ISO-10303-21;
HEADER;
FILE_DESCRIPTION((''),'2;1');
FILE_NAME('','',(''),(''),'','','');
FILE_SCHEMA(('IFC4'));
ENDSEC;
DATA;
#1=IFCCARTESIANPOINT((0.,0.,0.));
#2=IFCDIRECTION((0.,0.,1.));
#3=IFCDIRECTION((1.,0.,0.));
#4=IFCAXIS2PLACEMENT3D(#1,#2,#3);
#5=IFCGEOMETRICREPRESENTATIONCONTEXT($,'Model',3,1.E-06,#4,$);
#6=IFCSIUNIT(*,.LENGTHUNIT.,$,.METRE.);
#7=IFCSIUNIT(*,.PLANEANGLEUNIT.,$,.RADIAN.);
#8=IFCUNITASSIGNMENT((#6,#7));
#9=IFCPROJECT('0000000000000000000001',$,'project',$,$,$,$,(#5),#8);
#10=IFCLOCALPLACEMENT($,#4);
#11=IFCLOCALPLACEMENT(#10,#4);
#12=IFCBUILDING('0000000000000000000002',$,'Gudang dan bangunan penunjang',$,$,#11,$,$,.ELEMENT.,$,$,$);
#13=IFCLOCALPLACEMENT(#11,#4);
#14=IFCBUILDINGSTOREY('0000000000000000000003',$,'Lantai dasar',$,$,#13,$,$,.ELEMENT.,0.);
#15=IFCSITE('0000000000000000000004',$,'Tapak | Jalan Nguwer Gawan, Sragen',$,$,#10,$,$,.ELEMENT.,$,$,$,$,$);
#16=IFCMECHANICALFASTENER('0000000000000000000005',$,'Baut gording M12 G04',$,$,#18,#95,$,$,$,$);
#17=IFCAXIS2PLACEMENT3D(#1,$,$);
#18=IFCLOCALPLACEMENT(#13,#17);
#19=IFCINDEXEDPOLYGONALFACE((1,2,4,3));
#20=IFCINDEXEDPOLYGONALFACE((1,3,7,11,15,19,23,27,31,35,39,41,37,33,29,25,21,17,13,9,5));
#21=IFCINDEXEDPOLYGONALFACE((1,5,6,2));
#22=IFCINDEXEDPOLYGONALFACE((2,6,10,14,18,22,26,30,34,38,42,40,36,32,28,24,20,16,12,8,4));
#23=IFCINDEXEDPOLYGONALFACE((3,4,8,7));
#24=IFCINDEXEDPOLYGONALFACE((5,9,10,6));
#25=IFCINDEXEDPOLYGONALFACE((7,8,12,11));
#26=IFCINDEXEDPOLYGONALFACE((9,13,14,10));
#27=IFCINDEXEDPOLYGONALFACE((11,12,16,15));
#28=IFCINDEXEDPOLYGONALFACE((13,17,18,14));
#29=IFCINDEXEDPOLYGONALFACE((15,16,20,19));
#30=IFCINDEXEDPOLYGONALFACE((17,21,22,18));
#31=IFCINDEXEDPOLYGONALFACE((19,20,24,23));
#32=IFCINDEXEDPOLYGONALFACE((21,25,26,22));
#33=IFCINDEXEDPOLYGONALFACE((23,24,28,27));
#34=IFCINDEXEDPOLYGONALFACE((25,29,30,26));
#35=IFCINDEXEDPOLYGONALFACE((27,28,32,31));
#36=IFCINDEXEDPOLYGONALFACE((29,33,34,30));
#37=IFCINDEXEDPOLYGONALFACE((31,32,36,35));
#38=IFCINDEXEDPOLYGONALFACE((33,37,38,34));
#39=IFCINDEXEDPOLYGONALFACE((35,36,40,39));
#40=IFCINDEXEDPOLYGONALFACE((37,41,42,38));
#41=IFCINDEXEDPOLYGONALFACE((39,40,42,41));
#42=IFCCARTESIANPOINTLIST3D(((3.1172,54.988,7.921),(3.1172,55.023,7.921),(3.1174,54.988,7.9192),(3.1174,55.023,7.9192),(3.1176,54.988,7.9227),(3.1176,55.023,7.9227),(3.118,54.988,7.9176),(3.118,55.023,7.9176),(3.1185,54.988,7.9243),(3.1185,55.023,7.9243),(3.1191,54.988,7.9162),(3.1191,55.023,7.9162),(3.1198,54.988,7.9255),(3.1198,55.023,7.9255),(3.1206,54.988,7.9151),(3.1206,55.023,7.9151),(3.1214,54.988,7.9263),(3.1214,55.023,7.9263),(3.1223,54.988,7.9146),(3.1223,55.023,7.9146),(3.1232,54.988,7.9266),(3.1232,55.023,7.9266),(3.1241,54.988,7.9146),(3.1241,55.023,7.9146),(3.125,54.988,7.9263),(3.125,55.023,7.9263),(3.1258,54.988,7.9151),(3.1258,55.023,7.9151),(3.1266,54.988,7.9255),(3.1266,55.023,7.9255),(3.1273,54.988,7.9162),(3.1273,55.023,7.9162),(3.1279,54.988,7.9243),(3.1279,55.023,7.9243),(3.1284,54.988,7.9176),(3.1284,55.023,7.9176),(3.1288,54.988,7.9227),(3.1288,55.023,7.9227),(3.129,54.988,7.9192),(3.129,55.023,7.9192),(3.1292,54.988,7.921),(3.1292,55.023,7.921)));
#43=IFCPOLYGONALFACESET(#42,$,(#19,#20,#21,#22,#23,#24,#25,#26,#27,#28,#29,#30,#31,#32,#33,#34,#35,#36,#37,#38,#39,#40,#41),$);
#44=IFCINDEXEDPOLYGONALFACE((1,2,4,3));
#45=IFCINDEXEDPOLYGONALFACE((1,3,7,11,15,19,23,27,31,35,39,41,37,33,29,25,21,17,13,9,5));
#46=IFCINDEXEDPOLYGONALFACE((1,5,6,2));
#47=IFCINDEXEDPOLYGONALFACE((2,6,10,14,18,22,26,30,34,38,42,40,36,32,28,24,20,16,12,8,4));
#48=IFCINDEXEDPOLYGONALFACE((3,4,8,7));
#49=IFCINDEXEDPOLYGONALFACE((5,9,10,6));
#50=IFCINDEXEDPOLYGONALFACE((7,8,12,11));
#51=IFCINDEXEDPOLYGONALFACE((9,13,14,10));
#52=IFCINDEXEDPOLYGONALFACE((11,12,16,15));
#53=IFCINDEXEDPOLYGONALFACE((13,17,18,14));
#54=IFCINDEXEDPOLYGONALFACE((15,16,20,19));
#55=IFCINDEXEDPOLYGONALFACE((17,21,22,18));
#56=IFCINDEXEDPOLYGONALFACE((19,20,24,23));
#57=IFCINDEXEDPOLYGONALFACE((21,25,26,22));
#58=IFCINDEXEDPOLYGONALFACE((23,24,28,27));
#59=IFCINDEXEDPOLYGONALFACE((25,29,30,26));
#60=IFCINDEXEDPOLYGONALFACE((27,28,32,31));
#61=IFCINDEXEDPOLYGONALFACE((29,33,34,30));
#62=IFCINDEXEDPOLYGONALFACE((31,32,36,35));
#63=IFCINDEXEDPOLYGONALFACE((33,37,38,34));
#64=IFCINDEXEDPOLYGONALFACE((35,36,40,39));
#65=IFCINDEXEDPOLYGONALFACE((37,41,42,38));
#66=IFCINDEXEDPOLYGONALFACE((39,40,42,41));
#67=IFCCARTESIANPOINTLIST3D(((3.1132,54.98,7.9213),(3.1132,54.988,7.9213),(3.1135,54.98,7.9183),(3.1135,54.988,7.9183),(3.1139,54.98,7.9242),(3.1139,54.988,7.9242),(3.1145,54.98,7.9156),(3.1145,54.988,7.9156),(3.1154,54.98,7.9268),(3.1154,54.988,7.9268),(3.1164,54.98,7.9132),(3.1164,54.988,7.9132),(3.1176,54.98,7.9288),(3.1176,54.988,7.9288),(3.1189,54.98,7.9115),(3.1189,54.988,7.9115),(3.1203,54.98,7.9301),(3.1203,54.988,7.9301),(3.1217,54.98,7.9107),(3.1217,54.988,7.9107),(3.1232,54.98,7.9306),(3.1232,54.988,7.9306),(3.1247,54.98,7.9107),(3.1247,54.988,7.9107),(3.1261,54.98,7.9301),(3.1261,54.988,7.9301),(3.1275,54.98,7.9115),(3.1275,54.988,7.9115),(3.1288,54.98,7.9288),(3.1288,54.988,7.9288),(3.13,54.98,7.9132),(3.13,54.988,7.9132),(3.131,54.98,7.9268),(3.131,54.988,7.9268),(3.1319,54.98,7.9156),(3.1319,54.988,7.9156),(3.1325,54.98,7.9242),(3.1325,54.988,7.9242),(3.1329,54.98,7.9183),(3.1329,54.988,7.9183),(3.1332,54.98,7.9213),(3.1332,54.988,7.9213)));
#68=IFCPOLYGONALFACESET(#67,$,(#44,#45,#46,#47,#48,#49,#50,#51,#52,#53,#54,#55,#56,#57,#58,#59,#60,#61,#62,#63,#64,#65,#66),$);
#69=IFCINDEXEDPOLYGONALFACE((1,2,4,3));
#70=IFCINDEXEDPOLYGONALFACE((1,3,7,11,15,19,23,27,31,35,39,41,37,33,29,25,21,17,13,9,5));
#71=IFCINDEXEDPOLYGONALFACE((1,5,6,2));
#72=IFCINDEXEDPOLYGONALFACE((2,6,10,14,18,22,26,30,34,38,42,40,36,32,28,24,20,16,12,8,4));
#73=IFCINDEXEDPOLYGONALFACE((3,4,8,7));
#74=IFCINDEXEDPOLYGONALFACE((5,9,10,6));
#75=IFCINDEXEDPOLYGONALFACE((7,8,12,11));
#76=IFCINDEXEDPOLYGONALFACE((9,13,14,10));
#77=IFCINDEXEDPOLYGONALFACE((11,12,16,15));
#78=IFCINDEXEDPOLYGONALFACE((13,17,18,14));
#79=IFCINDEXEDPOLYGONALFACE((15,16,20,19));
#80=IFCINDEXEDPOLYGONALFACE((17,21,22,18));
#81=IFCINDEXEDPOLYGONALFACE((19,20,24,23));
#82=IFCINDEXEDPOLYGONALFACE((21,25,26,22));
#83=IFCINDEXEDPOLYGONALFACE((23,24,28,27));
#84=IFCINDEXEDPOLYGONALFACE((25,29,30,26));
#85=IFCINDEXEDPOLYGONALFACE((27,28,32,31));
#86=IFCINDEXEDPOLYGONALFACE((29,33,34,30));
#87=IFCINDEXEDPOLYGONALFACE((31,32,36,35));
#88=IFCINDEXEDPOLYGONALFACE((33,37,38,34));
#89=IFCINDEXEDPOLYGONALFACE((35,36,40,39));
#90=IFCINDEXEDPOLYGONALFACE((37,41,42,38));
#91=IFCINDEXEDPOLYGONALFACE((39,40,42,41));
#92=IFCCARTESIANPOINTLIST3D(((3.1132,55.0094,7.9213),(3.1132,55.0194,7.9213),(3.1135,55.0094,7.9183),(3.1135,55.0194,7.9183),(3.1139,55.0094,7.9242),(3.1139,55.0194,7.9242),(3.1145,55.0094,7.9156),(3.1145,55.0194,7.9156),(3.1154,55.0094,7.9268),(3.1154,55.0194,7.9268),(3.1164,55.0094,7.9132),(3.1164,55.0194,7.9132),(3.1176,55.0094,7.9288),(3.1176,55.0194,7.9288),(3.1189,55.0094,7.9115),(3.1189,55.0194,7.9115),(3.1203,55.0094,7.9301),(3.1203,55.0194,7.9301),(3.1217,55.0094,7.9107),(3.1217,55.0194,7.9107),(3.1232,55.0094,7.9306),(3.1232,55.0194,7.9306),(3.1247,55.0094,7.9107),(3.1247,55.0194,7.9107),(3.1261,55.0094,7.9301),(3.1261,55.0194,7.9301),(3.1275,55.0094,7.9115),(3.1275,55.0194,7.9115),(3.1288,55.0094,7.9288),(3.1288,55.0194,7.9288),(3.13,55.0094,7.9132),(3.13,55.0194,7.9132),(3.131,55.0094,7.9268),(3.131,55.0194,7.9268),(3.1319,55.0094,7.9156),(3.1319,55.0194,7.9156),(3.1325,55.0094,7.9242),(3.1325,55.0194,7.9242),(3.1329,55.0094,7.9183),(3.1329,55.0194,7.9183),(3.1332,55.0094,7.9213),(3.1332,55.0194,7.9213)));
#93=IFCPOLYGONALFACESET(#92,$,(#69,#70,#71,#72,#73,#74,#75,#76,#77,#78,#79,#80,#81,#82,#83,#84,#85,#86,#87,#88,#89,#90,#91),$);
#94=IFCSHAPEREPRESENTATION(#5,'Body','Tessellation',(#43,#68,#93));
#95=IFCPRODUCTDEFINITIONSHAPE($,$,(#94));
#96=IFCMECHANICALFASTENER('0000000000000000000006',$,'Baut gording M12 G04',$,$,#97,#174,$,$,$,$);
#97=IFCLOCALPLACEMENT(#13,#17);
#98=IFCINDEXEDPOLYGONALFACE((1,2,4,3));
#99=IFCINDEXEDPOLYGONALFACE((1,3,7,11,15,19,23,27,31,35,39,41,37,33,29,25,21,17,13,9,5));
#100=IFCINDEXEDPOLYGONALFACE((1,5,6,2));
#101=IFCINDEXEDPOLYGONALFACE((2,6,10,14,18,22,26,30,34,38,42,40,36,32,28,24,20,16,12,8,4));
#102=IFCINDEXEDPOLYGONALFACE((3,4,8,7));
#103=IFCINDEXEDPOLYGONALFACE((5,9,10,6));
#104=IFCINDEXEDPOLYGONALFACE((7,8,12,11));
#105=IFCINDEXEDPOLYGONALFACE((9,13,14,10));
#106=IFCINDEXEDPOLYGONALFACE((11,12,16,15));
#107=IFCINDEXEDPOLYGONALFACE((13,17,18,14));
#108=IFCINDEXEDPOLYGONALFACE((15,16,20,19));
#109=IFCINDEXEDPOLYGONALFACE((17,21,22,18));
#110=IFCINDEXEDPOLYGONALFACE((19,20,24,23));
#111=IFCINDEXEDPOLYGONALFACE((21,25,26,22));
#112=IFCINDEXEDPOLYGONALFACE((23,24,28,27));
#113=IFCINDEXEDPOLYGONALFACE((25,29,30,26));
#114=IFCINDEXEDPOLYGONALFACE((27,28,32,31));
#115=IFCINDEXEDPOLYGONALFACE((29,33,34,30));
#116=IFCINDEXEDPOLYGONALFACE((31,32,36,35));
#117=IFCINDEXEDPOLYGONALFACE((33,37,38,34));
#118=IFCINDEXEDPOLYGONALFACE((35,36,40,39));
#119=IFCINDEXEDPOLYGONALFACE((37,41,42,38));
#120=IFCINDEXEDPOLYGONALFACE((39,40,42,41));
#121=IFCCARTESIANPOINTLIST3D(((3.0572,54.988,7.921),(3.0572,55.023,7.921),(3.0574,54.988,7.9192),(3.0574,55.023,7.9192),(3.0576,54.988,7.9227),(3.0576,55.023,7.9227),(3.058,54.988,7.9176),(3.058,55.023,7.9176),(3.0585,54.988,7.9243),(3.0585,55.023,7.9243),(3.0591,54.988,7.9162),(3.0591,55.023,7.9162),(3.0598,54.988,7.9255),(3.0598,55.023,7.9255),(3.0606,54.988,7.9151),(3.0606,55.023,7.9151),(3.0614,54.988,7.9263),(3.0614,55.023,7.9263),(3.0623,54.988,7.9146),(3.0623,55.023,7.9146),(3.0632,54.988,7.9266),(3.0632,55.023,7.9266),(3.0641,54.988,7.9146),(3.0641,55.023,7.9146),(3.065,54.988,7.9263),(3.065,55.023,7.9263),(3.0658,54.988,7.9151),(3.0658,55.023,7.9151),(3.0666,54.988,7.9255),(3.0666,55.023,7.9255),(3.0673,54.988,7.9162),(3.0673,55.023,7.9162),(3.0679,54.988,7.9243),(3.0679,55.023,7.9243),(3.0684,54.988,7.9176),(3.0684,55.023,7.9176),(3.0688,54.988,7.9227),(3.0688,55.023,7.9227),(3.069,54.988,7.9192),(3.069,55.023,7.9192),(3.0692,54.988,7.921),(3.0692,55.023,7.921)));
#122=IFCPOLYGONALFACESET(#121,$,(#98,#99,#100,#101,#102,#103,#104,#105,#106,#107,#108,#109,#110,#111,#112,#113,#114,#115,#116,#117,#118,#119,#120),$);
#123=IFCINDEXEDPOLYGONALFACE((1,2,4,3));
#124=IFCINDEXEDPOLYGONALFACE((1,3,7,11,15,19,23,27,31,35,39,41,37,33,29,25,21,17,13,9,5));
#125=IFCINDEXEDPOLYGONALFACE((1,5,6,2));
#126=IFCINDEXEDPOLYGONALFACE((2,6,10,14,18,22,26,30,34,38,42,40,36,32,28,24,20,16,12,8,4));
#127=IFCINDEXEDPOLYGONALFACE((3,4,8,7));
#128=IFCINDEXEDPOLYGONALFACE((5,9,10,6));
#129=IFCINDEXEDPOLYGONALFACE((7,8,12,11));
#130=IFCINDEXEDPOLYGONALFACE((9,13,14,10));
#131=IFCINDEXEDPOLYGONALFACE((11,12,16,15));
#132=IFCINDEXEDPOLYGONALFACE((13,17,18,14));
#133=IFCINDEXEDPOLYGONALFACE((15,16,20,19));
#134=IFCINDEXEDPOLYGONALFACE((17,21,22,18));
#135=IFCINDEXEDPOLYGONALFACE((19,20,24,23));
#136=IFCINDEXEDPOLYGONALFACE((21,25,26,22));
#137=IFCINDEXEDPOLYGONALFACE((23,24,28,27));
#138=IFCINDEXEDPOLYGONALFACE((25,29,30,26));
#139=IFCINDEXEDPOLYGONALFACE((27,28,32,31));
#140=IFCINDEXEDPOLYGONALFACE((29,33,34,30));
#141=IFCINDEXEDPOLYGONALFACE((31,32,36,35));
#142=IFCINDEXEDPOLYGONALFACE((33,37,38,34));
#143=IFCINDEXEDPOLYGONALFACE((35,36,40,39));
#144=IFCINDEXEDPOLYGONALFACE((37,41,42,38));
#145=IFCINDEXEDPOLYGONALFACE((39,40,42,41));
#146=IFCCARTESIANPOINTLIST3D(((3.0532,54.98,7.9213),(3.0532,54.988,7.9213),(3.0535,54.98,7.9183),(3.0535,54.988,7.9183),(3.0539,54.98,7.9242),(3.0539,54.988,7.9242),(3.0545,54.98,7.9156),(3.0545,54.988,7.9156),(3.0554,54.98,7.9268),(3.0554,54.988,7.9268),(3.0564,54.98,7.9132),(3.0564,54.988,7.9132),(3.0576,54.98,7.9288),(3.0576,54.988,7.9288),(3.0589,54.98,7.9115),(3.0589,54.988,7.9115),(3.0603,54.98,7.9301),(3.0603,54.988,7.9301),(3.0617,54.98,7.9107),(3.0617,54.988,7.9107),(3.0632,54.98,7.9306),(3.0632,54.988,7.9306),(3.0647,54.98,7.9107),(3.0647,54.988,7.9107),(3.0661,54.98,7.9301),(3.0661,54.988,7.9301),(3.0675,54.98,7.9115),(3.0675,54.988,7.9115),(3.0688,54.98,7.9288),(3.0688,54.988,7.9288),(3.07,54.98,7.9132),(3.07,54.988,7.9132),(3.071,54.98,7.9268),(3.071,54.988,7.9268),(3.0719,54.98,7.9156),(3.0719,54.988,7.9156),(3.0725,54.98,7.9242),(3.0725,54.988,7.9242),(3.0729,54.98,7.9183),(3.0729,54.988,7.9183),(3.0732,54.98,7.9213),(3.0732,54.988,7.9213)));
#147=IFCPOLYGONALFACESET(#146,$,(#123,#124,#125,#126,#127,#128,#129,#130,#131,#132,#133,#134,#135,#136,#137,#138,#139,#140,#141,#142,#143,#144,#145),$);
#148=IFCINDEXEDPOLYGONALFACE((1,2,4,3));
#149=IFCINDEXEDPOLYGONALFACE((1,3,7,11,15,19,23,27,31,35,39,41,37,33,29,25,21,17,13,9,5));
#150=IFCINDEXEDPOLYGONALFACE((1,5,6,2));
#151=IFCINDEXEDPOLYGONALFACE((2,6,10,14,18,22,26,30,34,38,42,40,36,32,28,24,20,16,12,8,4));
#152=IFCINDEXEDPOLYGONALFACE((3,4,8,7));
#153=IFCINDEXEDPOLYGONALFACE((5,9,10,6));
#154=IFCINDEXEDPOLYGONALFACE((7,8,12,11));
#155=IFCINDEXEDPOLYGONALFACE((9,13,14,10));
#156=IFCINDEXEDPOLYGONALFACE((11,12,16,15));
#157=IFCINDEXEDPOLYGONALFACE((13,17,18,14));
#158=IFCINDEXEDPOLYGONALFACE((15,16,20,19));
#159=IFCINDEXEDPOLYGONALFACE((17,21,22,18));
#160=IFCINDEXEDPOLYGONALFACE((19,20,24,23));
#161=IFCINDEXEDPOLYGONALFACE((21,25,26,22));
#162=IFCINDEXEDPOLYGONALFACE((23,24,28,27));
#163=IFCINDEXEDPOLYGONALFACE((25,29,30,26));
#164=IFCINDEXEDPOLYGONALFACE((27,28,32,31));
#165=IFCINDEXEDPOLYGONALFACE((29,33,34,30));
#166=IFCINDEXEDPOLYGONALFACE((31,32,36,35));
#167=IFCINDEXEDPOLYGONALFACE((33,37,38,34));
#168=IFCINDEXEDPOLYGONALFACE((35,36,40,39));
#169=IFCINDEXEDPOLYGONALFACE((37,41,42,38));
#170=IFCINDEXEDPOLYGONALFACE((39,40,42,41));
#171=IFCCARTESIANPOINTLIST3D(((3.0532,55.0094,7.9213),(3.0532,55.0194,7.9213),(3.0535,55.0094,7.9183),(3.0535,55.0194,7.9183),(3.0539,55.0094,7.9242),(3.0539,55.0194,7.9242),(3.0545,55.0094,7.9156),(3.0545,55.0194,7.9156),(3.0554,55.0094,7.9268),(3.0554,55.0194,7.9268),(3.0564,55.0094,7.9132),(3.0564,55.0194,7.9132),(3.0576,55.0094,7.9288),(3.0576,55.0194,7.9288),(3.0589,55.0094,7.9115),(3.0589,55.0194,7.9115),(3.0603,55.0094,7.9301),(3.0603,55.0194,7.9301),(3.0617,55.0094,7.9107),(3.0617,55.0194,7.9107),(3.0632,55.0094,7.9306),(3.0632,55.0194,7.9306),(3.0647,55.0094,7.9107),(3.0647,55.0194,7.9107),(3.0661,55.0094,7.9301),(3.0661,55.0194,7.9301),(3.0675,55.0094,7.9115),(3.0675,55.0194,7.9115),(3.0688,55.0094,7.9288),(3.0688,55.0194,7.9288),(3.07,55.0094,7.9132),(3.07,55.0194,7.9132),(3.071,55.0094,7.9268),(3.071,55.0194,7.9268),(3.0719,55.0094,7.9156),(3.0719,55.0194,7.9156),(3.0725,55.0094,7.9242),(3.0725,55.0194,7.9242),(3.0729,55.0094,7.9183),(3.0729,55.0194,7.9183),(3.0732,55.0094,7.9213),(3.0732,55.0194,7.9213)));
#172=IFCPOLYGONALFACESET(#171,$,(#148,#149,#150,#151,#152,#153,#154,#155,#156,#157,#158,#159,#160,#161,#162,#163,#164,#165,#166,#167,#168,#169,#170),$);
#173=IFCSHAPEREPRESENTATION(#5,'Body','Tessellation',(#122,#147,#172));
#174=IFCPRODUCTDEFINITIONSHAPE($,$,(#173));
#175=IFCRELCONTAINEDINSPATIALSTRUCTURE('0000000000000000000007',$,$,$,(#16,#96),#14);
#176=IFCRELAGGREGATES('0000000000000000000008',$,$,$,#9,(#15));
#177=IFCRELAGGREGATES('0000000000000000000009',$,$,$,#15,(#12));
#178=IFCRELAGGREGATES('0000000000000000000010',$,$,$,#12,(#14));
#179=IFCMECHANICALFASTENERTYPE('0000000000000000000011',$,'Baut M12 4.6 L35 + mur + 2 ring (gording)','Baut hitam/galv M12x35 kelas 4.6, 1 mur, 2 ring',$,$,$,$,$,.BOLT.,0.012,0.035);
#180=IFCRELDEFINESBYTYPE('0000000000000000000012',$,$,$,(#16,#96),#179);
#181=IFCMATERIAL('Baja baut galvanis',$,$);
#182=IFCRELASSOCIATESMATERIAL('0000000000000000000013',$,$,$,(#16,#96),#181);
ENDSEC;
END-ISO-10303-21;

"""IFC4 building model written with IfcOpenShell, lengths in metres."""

from ifc_helpers import new_model, si_unit, frame, origin_with_axes, place, context, project, spatial, circle, extrude, source, transform, mapped, material, type_object, type_shapes, element, save


model = new_model("IFC4")

# Units and contexts
model_context = context("Model", 3, precision=1e-06, world=origin_with_axes())
ifc_project = project(units=[si_unit("LENGTHUNIT", "METRE"), si_unit("PLANEANGLEUNIT", "RADIAN")], contexts=[model_context])

# Site, building, storey
site_placement = place(None, origin_with_axes())
site = spatial("IfcSite", under=ifc_project, at=site_placement, Name="Tapak | Jalan Nguwer Gawan, Sragen", CompositionType="ELEMENT")
building_placement = place(site_placement, origin_with_axes())
building = spatial("IfcBuilding", under=site, at=building_placement, Name="Gudang dan bangunan penunjang", CompositionType="ELEMENT")
storey_placement = place(building_placement, origin_with_axes())
storey = spatial("IfcBuildingStorey", under=building, at=storey_placement, Name="Lantai dasar", CompositionType="ELEMENT", Elevation=0.0)

# Shared definitions
placement = place(None, origin_with_axes())

# Mechanical fasteners
ifc_material_1 = material(Name="Baja baut galvanis")
mechanical_fastener_type = type_object("IfcMechanicalFastenerType", Name="Baut M12 4.6 L35 + mur + 2 ring (gording)", Description="Baut hitam/galv M12x35 kelas 4.6, 1 mur, 2 ring", NominalDiameter=0.012, NominalLength=0.035, PredefinedType="BOLT")
shared_shape = source(origin_with_axes(), model_context, "Body", "SweptSolid", [
    extrude(circle(Radius=0.006), origin_with_axes(), (0.0, 0.0, 1.0), 0.035),
    extrude(circle(Radius=0.01), frame((0.0, 0.0, -0.008), z_axis=(0.0, 0.0, 1.0), x_axis=(1.0, 0.0, 0.0)), (0.0, 0.0, 1.0), 0.008),
    extrude(circle(Radius=0.01), frame((0.0, 0.0, 0.0214), z_axis=(0.0, 0.0, 1.0), x_axis=(1.0, 0.0, 0.0)), (0.0, 0.0, 1.0), 0.01),
])
type_shapes(mechanical_fastener_type, [shared_shape])
element("IfcMechanicalFastener", 1, at=placement, inside=storey, type_object=mechanical_fastener_type, material=ifc_material_1, Name="Baut gording M12 G04", context=model_context, shape_type="MappedRepresentation", body=[
    mapped(shared_shape, transform((3.1232, 54.988, 7.9206), x_axis=(0.0, 0.0, 1.0), y_axis=(1.0, 0.0, 0.0), z_axis=(0.0, 1.0, 0.0), scale=1.0)),
])
element("IfcMechanicalFastener", 2, at=placement, inside=storey, type_object=mechanical_fastener_type, material=ifc_material_1, Name="Baut gording M12 G04", context=model_context, shape_type="MappedRepresentation", body=[
    mapped(shared_shape, transform((3.0632, 54.988, 7.9206), x_axis=(0.0, 0.0, 1.0), y_axis=(1.0, 0.0, 0.0), z_axis=(0.0, 1.0, 0.0), scale=1.0)),
])

save(model, "model.ifc")
